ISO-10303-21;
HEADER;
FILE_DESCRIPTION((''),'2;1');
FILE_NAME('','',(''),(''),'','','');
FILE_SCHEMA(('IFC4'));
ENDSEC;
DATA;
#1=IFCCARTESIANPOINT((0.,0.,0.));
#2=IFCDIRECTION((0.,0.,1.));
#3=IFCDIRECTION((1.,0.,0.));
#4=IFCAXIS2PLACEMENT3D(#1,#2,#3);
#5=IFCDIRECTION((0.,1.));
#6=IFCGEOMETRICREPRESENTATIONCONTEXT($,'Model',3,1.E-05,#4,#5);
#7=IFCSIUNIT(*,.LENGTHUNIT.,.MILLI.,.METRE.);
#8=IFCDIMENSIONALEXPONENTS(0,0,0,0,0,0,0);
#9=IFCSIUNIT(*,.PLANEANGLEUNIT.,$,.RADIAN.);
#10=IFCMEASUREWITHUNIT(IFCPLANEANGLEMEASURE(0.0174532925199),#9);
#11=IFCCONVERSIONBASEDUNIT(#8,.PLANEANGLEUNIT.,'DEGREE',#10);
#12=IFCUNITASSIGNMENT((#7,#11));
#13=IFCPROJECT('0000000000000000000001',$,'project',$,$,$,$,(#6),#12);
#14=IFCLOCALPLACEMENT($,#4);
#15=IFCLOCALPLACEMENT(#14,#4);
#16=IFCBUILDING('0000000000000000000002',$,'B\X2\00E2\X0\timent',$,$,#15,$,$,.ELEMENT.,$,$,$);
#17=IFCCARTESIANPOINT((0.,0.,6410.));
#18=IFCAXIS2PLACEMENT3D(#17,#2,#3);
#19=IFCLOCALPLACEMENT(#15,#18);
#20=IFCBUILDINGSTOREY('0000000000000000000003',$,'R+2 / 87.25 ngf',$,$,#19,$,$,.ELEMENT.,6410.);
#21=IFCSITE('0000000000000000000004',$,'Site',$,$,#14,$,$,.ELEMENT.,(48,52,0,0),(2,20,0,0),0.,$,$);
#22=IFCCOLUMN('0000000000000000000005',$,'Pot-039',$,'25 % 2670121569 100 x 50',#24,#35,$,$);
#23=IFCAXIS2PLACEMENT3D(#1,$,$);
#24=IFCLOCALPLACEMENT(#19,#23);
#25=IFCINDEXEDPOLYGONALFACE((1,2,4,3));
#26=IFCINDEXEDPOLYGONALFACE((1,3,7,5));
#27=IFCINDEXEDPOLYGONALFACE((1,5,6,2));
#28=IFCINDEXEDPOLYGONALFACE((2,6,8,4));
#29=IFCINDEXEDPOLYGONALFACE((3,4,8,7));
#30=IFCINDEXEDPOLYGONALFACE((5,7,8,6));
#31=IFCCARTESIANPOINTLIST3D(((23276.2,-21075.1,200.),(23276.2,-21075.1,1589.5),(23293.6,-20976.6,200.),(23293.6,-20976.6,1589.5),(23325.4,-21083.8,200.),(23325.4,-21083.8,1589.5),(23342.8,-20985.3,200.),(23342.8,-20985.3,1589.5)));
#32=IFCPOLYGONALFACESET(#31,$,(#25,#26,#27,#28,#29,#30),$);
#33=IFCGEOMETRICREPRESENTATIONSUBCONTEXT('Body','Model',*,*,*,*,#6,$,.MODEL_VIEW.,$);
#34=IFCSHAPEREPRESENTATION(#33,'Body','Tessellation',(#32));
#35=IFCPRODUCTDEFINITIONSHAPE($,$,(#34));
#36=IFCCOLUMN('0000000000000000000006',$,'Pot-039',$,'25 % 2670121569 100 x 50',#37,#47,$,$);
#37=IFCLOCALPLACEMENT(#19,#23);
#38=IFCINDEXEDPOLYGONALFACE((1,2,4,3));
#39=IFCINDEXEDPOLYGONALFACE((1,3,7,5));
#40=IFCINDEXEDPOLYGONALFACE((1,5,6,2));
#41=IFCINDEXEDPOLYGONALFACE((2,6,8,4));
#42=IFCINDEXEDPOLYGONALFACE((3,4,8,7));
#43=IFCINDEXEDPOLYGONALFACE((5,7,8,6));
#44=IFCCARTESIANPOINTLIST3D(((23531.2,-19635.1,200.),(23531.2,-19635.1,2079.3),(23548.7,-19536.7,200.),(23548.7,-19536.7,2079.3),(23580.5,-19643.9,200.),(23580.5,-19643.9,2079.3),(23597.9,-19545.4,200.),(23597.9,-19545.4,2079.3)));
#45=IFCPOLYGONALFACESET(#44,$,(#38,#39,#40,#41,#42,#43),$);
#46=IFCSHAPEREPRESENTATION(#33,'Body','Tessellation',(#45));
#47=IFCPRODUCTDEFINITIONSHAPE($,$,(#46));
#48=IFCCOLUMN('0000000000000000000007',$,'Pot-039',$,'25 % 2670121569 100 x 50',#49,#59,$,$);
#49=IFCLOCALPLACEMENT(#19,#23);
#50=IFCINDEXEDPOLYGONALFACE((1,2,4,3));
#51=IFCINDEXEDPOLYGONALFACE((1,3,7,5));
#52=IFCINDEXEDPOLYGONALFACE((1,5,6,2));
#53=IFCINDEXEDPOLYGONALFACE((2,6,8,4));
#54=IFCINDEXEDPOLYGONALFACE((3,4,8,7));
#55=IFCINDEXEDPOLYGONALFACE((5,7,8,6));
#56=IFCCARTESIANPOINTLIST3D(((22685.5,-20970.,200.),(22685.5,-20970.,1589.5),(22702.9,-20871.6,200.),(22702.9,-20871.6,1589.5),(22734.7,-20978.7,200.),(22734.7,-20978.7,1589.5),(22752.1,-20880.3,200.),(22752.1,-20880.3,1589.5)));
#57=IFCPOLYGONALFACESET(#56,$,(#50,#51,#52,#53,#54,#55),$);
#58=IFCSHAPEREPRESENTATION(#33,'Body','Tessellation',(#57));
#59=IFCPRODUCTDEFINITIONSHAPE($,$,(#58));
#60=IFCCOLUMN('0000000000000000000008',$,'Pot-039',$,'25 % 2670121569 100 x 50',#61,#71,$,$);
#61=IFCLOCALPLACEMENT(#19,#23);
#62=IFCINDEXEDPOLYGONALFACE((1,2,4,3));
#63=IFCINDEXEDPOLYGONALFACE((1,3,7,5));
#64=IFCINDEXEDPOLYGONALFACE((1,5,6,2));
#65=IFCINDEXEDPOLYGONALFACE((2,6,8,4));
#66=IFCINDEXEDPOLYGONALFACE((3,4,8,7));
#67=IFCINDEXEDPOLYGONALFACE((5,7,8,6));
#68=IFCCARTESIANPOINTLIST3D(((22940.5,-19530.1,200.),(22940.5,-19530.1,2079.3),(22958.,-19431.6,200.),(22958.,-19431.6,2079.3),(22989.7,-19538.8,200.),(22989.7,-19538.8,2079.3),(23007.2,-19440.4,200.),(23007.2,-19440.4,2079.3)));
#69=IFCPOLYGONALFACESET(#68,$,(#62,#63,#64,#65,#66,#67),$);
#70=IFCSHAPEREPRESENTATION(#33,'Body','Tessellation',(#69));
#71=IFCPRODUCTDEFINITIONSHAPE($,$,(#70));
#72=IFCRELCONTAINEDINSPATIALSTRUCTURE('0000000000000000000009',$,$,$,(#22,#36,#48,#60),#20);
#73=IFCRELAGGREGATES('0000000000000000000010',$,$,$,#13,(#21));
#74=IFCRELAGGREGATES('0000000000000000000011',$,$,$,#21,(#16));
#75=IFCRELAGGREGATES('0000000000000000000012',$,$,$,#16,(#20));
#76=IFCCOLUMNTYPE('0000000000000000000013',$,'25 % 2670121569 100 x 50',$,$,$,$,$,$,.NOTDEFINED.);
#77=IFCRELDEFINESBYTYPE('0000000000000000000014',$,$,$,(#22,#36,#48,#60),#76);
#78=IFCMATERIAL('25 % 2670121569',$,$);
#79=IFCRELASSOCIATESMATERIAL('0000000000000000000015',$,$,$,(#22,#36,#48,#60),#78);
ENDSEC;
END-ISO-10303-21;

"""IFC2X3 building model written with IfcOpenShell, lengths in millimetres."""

from ifc_helpers import new_model, entity, si_unit, converted_unit, direction, frame, origin_with_axes, origin_2d_with_axis, place, context, subcontext, project, spatial, rectangle, extrude, material, type_object, element, save


model = new_model("IFC2X3")

# Units and contexts
model_context = context("Model", 3, precision=1e-05, world=origin_with_axes(), true_north=direction((0.0, 1.0)))
body_context = subcontext(model_context, "Body", "Model", "MODEL_VIEW")
ifc_project = project(units=[si_unit("LENGTHUNIT", "METRE", prefix="MILLI"), converted_unit("PLANEANGLEUNIT", "DEGREE", entity("IfcPlaneAngleMeasure", 0.0174532925199), si_unit("PLANEANGLEUNIT", "RADIAN"), dimensions=[0, 0, 0, 0, 0, 0, 0])], contexts=[model_context])

# Site, building, storey
site_placement = place(None, origin_with_axes())
site = spatial("IfcSite", under=ifc_project, at=site_placement, Name="Site", CompositionType="ELEMENT", RefLatitude=(48, 52, 0, 0), RefLongitude=(2, 20, 0, 0), RefElevation=0.0)
building_placement = place(site_placement, origin_with_axes())
building = spatial("IfcBuilding", under=site, at=building_placement, Name="Bâtiment", CompositionType="ELEMENT")
storey_placement = place(building_placement, frame((0.0, 0.0, 6410.0), z_axis=(0.0, 0.0, 1.0), x_axis=(1.0, 0.0, 0.0)))
storey = spatial("IfcBuildingStorey", under=building, at=storey_placement, Name="R+2 / 87.25 ngf", CompositionType="ELEMENT", Elevation=6410.0)

# Columns
ifc_material_1 = material(Name="25 % 2670121569")
column_type = type_object("IfcColumnType", Name="25 % 2670121569 100 x 50", PredefinedType="NOTDEFINED")
column_1_placement = place(storey_placement, frame((23309.5, -21030.2, 200.0), z_axis=(0.0, 0.0, 1.0), x_axis=(0.17408, 0.984731, 0.0)))
element("IfcColumn", 1, at=column_1_placement, inside=storey, type_object=column_type, material=ifc_material_1, Name="Pot-039", ObjectType="25 % 2670121569 100 x 50", context=body_context, shape_type="SweptSolid", body=[
    extrude(rectangle(XDim=100.0, YDim=50.0, at=origin_2d_with_axis()), origin_with_axes(), (0.0, 0.0, 1.0), 1389.5),
])
column_2_placement = place(storey_placement, frame((23564.6, -19590.3, 200.0), z_axis=(0.0, 0.0, 1.0), x_axis=(0.17478, 0.984607, 0.0)))
element("IfcColumn", 2, at=column_2_placement, inside=storey, type_object=column_type, material=ifc_material_1, Name="Pot-039", ObjectType="25 % 2670121569 100 x 50", context=body_context, shape_type="SweptSolid", body=[
    extrude(rectangle(XDim=100.0, YDim=50.0, at=origin_2d_with_axis()), origin_with_axes(), (0.0, 0.0, 1.0), 1879.3),
])
column_3_placement = place(storey_placement, frame((22718.8, -20925.1, 200.0), z_axis=(0.0, 0.0, 1.0), x_axis=(0.17408, 0.984731, 0.0)))
element("IfcColumn", 3, at=column_3_placement, inside=storey, type_object=column_type, material=ifc_material_1, Name="Pot-039", ObjectType="25 % 2670121569 100 x 50", context=body_context, shape_type="SweptSolid", body=[
    extrude(rectangle(XDim=100.0, YDim=50.0, at=origin_2d_with_axis()), origin_with_axes(), (0.0, 0.0, 1.0), 1389.5),
])
column_4_placement = place(storey_placement, frame((22973.9, -19485.2, 200.0), z_axis=(0.0, 0.0, 1.0), x_axis=(0.17478, 0.984607, 0.0)))
element("IfcColumn", 4, at=column_4_placement, inside=storey, type_object=column_type, material=ifc_material_1, Name="Pot-039", ObjectType="25 % 2670121569 100 x 50", context=body_context, shape_type="SweptSolid", body=[
    extrude(rectangle(XDim=100.0, YDim=50.0, at=origin_2d_with_axis()), origin_with_axes(), (0.0, 0.0, 1.0), 1879.3),
])

save(model, "model.ifc")
